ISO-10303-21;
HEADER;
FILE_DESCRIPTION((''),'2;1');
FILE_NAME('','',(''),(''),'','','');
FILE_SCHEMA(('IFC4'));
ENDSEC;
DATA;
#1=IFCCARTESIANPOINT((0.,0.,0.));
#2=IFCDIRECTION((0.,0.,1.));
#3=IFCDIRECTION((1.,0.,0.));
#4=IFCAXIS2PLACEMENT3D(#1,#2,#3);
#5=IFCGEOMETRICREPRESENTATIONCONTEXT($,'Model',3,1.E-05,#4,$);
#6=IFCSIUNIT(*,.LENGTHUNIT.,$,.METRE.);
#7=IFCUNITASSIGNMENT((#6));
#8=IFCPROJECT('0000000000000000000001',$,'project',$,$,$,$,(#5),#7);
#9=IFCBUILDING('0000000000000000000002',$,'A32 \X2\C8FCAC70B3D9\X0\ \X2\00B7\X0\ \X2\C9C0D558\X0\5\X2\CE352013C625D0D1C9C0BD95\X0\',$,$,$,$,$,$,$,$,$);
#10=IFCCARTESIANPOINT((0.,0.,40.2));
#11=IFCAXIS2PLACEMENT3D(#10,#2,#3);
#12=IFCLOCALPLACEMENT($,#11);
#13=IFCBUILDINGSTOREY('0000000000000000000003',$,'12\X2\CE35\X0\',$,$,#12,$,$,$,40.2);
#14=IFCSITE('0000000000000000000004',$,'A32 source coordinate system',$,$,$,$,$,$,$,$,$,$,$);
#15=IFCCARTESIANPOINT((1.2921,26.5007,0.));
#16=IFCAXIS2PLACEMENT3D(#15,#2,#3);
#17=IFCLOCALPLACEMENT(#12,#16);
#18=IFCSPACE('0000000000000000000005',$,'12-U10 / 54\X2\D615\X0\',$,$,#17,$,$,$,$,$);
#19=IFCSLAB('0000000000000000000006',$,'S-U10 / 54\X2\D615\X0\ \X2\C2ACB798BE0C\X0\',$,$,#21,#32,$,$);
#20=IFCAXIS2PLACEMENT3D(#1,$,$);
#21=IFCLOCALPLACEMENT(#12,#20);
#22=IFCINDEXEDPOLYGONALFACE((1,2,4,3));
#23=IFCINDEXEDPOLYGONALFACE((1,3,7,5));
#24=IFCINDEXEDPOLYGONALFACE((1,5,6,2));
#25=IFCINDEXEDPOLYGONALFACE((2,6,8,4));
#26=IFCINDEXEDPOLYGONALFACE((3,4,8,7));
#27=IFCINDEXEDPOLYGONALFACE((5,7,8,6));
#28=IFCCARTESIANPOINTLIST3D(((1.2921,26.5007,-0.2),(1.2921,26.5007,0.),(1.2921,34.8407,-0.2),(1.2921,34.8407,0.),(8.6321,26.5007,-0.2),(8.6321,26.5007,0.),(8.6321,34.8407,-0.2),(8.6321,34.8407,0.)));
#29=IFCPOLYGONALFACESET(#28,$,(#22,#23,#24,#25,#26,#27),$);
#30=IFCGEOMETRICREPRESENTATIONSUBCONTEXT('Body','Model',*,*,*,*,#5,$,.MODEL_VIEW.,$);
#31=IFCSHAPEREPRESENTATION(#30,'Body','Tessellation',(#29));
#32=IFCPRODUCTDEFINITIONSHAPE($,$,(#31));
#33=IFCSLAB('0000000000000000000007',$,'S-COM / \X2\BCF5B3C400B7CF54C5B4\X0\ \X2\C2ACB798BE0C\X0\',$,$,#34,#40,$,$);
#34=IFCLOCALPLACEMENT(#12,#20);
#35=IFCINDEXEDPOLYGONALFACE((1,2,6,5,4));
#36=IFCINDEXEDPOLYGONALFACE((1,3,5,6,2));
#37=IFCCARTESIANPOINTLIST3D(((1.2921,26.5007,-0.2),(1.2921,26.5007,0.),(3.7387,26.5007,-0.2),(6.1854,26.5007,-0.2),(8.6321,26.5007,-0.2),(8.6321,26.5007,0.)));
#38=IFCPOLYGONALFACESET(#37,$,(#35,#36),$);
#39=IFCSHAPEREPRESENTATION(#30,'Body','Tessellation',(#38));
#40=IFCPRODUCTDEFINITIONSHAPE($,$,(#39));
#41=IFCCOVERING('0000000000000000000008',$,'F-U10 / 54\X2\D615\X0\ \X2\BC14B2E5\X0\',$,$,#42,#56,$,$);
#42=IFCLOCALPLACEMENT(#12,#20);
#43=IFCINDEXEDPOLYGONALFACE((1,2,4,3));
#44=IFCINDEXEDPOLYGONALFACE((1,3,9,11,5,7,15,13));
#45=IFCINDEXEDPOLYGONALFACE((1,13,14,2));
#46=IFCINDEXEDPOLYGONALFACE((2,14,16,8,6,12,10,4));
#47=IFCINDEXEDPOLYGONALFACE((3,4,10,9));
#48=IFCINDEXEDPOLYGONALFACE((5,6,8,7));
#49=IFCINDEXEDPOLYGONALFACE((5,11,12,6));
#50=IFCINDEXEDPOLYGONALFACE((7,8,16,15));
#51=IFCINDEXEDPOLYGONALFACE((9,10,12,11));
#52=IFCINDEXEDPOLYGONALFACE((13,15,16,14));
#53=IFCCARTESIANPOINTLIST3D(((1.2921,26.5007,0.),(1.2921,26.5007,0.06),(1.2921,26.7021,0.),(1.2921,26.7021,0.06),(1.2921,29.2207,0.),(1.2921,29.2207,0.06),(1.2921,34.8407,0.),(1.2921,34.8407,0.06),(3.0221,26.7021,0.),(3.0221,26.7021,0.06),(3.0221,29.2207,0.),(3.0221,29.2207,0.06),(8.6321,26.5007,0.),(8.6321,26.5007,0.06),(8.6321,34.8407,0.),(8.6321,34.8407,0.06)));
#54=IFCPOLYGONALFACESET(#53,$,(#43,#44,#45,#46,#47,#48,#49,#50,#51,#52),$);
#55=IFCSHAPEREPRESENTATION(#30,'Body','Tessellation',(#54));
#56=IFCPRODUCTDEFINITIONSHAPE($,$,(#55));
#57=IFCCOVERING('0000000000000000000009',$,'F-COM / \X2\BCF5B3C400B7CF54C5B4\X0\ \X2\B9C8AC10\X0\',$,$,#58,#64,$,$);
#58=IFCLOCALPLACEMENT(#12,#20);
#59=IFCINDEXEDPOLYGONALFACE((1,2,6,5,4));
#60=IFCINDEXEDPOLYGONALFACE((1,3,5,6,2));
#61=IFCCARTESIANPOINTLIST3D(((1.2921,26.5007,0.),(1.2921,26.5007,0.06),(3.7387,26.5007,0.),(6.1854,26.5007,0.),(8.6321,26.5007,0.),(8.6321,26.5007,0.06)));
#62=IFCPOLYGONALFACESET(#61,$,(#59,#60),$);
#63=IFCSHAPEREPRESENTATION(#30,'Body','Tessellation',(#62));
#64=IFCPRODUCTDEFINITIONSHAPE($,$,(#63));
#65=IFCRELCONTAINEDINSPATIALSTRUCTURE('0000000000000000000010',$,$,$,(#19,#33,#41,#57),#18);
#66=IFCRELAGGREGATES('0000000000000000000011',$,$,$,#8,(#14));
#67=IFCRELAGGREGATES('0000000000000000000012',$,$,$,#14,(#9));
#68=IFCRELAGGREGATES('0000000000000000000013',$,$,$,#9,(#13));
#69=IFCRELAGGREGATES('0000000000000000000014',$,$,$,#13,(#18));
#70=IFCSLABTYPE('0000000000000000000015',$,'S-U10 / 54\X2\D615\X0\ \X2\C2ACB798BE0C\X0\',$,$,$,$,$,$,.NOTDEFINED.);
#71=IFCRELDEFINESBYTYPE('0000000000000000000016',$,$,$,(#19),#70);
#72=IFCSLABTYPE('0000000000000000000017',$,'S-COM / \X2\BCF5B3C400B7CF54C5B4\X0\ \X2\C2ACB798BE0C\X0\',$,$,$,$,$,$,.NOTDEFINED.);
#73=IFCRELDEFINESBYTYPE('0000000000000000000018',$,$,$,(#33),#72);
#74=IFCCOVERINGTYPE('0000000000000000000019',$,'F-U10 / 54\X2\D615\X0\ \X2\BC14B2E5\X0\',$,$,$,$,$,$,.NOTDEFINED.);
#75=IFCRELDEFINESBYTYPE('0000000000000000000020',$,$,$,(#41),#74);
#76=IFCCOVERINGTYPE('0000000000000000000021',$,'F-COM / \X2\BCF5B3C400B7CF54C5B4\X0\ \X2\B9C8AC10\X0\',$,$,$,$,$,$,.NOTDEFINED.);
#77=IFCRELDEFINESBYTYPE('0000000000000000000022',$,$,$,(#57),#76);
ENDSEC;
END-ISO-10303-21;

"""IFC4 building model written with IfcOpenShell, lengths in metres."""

from ifc_helpers import new_model, si_unit, frame, origin, origin_with_axes, place, context, subcontext, project, spatial, polyline, outline, extrude, source, transform, mapped, type_object, type_shapes, element, save


model = new_model("IFC4")

# Units and contexts
model_context = context("Model", 3, precision=1e-05, world=origin_with_axes())
body_context = subcontext(model_context, "Body", "Model", "MODEL_VIEW")
ifc_project = project(units=[si_unit("LENGTHUNIT", "METRE")], contexts=[model_context])

# Site, building, storey, space
storey_placement = place(None, frame((0.0, 0.0, 40.2), z_axis=(0.0, 0.0, 1.0), x_axis=(1.0, 0.0, 0.0)))
space_placement = place(storey_placement, frame((1.2921, 26.5007, 0.0), z_axis=(0.0, 0.0, 1.0), x_axis=(1.0, 0.0, 0.0)))
site = spatial("IfcSite", under=ifc_project, Name="A32 source coordinate system")
building = spatial("IfcBuilding", under=site, Name="A32 주거동 · 지하5층–옥탑지붕")
storey = spatial("IfcBuildingStorey", under=building, at=storey_placement, Name="12층", Elevation=40.2)
space = spatial("IfcSpace", under=storey, at=space_placement, Name="12-U10 / 54형")

# Slabs
slab_type_1 = type_object("IfcSlabType", Name="S-U10 / 54형 슬래브", PredefinedType="NOTDEFINED")
shared_shape_1 = source(origin(), body_context, "Body", "SweptSolid", [
    extrude(outline(polyline([(0.0, 0.0), (0.0, 8.34), (7.34, 8.34), (7.34, 0.0), (0.0, 0.0)])), frame((0.0, 0.0, -0.2)), (0.0, 0.0, 1.0), 0.2),
])
type_shapes(slab_type_1, [shared_shape_1])
slab_1_placement = place(space_placement, origin_with_axes())
element("IfcSlab", 1, at=slab_1_placement, inside=space, type_object=slab_type_1, Name="S-U10 / 54형 슬래브", context=body_context, shape_type="MappedRepresentation", body=[
    mapped(shared_shape_1, transform((0.0, 0.0, 0.0), scale=1.0)),
])
slab_type_2 = type_object("IfcSlabType", Name="S-COM / 복도·코어 슬래브", PredefinedType="NOTDEFINED")
shared_shape_2 = source(origin(), body_context, "Body", "SweptSolid", [
    extrude(outline(polyline([(7.34, 0.0), (7.34, 0.0), (0.0, 0.0), (0.0, 0.0), (7.34, 0.0)])), frame((0.0, 0.0, -0.2)), (0.0, 0.0, 1.0), 0.2),
])
type_shapes(slab_type_2, [shared_shape_2])
slab_2_placement = place(space_placement, origin_with_axes())
element("IfcSlab", 2, at=slab_2_placement, inside=space, type_object=slab_type_2, Name="S-COM / 복도·코어 슬래브", context=body_context, shape_type="MappedRepresentation", body=[
    mapped(shared_shape_2, transform((0.0, 0.0, 0.0), scale=1.0)),
])

# Coverings
covering_type_1 = type_object("IfcCoveringType", Name="F-U10 / 54형 바닥", PredefinedType="NOTDEFINED")
shared_shape_3 = source(origin(), body_context, "Body", "SweptSolid", [
    extrude(outline(polyline([(7.34, 0.0), (0.0, 0.0), (0.0, 0.2014), (1.73, 0.2014), (1.73, 2.72), (0.0, 2.72), (0.0, 8.34), (7.34, 8.34), (7.34, 0.0)])), origin(), (0.0, 0.0, 1.0), 0.06),
])
type_shapes(covering_type_1, [shared_shape_3])
covering_1_placement = place(space_placement, origin_with_axes())
element("IfcCovering", 3, at=covering_1_placement, inside=space, type_object=covering_type_1, Name="F-U10 / 54형 바닥", context=body_context, shape_type="MappedRepresentation", body=[
    mapped(shared_shape_3, transform((0.0, 0.0, 0.0), scale=1.0)),
])
covering_type_2 = type_object("IfcCoveringType", Name="F-COM / 복도·코어 마감", PredefinedType="NOTDEFINED")
shared_shape_4 = source(origin(), body_context, "Body", "SweptSolid", [
    extrude(outline(polyline([(7.34, 0.0), (7.34, 0.0), (0.0, 0.0), (0.0, 0.0), (7.34, 0.0)])), origin(), (0.0, 0.0, 1.0), 0.06),
])
type_shapes(covering_type_2, [shared_shape_4])
covering_2_placement = place(space_placement, origin_with_axes())
element("IfcCovering", 4, at=covering_2_placement, inside=space, type_object=covering_type_2, Name="F-COM / 복도·코어 마감", context=body_context, shape_type="MappedRepresentation", body=[
    mapped(shared_shape_4, transform((0.0, 0.0, 0.0), scale=1.0)),
])

save(model, "model.ifc")
